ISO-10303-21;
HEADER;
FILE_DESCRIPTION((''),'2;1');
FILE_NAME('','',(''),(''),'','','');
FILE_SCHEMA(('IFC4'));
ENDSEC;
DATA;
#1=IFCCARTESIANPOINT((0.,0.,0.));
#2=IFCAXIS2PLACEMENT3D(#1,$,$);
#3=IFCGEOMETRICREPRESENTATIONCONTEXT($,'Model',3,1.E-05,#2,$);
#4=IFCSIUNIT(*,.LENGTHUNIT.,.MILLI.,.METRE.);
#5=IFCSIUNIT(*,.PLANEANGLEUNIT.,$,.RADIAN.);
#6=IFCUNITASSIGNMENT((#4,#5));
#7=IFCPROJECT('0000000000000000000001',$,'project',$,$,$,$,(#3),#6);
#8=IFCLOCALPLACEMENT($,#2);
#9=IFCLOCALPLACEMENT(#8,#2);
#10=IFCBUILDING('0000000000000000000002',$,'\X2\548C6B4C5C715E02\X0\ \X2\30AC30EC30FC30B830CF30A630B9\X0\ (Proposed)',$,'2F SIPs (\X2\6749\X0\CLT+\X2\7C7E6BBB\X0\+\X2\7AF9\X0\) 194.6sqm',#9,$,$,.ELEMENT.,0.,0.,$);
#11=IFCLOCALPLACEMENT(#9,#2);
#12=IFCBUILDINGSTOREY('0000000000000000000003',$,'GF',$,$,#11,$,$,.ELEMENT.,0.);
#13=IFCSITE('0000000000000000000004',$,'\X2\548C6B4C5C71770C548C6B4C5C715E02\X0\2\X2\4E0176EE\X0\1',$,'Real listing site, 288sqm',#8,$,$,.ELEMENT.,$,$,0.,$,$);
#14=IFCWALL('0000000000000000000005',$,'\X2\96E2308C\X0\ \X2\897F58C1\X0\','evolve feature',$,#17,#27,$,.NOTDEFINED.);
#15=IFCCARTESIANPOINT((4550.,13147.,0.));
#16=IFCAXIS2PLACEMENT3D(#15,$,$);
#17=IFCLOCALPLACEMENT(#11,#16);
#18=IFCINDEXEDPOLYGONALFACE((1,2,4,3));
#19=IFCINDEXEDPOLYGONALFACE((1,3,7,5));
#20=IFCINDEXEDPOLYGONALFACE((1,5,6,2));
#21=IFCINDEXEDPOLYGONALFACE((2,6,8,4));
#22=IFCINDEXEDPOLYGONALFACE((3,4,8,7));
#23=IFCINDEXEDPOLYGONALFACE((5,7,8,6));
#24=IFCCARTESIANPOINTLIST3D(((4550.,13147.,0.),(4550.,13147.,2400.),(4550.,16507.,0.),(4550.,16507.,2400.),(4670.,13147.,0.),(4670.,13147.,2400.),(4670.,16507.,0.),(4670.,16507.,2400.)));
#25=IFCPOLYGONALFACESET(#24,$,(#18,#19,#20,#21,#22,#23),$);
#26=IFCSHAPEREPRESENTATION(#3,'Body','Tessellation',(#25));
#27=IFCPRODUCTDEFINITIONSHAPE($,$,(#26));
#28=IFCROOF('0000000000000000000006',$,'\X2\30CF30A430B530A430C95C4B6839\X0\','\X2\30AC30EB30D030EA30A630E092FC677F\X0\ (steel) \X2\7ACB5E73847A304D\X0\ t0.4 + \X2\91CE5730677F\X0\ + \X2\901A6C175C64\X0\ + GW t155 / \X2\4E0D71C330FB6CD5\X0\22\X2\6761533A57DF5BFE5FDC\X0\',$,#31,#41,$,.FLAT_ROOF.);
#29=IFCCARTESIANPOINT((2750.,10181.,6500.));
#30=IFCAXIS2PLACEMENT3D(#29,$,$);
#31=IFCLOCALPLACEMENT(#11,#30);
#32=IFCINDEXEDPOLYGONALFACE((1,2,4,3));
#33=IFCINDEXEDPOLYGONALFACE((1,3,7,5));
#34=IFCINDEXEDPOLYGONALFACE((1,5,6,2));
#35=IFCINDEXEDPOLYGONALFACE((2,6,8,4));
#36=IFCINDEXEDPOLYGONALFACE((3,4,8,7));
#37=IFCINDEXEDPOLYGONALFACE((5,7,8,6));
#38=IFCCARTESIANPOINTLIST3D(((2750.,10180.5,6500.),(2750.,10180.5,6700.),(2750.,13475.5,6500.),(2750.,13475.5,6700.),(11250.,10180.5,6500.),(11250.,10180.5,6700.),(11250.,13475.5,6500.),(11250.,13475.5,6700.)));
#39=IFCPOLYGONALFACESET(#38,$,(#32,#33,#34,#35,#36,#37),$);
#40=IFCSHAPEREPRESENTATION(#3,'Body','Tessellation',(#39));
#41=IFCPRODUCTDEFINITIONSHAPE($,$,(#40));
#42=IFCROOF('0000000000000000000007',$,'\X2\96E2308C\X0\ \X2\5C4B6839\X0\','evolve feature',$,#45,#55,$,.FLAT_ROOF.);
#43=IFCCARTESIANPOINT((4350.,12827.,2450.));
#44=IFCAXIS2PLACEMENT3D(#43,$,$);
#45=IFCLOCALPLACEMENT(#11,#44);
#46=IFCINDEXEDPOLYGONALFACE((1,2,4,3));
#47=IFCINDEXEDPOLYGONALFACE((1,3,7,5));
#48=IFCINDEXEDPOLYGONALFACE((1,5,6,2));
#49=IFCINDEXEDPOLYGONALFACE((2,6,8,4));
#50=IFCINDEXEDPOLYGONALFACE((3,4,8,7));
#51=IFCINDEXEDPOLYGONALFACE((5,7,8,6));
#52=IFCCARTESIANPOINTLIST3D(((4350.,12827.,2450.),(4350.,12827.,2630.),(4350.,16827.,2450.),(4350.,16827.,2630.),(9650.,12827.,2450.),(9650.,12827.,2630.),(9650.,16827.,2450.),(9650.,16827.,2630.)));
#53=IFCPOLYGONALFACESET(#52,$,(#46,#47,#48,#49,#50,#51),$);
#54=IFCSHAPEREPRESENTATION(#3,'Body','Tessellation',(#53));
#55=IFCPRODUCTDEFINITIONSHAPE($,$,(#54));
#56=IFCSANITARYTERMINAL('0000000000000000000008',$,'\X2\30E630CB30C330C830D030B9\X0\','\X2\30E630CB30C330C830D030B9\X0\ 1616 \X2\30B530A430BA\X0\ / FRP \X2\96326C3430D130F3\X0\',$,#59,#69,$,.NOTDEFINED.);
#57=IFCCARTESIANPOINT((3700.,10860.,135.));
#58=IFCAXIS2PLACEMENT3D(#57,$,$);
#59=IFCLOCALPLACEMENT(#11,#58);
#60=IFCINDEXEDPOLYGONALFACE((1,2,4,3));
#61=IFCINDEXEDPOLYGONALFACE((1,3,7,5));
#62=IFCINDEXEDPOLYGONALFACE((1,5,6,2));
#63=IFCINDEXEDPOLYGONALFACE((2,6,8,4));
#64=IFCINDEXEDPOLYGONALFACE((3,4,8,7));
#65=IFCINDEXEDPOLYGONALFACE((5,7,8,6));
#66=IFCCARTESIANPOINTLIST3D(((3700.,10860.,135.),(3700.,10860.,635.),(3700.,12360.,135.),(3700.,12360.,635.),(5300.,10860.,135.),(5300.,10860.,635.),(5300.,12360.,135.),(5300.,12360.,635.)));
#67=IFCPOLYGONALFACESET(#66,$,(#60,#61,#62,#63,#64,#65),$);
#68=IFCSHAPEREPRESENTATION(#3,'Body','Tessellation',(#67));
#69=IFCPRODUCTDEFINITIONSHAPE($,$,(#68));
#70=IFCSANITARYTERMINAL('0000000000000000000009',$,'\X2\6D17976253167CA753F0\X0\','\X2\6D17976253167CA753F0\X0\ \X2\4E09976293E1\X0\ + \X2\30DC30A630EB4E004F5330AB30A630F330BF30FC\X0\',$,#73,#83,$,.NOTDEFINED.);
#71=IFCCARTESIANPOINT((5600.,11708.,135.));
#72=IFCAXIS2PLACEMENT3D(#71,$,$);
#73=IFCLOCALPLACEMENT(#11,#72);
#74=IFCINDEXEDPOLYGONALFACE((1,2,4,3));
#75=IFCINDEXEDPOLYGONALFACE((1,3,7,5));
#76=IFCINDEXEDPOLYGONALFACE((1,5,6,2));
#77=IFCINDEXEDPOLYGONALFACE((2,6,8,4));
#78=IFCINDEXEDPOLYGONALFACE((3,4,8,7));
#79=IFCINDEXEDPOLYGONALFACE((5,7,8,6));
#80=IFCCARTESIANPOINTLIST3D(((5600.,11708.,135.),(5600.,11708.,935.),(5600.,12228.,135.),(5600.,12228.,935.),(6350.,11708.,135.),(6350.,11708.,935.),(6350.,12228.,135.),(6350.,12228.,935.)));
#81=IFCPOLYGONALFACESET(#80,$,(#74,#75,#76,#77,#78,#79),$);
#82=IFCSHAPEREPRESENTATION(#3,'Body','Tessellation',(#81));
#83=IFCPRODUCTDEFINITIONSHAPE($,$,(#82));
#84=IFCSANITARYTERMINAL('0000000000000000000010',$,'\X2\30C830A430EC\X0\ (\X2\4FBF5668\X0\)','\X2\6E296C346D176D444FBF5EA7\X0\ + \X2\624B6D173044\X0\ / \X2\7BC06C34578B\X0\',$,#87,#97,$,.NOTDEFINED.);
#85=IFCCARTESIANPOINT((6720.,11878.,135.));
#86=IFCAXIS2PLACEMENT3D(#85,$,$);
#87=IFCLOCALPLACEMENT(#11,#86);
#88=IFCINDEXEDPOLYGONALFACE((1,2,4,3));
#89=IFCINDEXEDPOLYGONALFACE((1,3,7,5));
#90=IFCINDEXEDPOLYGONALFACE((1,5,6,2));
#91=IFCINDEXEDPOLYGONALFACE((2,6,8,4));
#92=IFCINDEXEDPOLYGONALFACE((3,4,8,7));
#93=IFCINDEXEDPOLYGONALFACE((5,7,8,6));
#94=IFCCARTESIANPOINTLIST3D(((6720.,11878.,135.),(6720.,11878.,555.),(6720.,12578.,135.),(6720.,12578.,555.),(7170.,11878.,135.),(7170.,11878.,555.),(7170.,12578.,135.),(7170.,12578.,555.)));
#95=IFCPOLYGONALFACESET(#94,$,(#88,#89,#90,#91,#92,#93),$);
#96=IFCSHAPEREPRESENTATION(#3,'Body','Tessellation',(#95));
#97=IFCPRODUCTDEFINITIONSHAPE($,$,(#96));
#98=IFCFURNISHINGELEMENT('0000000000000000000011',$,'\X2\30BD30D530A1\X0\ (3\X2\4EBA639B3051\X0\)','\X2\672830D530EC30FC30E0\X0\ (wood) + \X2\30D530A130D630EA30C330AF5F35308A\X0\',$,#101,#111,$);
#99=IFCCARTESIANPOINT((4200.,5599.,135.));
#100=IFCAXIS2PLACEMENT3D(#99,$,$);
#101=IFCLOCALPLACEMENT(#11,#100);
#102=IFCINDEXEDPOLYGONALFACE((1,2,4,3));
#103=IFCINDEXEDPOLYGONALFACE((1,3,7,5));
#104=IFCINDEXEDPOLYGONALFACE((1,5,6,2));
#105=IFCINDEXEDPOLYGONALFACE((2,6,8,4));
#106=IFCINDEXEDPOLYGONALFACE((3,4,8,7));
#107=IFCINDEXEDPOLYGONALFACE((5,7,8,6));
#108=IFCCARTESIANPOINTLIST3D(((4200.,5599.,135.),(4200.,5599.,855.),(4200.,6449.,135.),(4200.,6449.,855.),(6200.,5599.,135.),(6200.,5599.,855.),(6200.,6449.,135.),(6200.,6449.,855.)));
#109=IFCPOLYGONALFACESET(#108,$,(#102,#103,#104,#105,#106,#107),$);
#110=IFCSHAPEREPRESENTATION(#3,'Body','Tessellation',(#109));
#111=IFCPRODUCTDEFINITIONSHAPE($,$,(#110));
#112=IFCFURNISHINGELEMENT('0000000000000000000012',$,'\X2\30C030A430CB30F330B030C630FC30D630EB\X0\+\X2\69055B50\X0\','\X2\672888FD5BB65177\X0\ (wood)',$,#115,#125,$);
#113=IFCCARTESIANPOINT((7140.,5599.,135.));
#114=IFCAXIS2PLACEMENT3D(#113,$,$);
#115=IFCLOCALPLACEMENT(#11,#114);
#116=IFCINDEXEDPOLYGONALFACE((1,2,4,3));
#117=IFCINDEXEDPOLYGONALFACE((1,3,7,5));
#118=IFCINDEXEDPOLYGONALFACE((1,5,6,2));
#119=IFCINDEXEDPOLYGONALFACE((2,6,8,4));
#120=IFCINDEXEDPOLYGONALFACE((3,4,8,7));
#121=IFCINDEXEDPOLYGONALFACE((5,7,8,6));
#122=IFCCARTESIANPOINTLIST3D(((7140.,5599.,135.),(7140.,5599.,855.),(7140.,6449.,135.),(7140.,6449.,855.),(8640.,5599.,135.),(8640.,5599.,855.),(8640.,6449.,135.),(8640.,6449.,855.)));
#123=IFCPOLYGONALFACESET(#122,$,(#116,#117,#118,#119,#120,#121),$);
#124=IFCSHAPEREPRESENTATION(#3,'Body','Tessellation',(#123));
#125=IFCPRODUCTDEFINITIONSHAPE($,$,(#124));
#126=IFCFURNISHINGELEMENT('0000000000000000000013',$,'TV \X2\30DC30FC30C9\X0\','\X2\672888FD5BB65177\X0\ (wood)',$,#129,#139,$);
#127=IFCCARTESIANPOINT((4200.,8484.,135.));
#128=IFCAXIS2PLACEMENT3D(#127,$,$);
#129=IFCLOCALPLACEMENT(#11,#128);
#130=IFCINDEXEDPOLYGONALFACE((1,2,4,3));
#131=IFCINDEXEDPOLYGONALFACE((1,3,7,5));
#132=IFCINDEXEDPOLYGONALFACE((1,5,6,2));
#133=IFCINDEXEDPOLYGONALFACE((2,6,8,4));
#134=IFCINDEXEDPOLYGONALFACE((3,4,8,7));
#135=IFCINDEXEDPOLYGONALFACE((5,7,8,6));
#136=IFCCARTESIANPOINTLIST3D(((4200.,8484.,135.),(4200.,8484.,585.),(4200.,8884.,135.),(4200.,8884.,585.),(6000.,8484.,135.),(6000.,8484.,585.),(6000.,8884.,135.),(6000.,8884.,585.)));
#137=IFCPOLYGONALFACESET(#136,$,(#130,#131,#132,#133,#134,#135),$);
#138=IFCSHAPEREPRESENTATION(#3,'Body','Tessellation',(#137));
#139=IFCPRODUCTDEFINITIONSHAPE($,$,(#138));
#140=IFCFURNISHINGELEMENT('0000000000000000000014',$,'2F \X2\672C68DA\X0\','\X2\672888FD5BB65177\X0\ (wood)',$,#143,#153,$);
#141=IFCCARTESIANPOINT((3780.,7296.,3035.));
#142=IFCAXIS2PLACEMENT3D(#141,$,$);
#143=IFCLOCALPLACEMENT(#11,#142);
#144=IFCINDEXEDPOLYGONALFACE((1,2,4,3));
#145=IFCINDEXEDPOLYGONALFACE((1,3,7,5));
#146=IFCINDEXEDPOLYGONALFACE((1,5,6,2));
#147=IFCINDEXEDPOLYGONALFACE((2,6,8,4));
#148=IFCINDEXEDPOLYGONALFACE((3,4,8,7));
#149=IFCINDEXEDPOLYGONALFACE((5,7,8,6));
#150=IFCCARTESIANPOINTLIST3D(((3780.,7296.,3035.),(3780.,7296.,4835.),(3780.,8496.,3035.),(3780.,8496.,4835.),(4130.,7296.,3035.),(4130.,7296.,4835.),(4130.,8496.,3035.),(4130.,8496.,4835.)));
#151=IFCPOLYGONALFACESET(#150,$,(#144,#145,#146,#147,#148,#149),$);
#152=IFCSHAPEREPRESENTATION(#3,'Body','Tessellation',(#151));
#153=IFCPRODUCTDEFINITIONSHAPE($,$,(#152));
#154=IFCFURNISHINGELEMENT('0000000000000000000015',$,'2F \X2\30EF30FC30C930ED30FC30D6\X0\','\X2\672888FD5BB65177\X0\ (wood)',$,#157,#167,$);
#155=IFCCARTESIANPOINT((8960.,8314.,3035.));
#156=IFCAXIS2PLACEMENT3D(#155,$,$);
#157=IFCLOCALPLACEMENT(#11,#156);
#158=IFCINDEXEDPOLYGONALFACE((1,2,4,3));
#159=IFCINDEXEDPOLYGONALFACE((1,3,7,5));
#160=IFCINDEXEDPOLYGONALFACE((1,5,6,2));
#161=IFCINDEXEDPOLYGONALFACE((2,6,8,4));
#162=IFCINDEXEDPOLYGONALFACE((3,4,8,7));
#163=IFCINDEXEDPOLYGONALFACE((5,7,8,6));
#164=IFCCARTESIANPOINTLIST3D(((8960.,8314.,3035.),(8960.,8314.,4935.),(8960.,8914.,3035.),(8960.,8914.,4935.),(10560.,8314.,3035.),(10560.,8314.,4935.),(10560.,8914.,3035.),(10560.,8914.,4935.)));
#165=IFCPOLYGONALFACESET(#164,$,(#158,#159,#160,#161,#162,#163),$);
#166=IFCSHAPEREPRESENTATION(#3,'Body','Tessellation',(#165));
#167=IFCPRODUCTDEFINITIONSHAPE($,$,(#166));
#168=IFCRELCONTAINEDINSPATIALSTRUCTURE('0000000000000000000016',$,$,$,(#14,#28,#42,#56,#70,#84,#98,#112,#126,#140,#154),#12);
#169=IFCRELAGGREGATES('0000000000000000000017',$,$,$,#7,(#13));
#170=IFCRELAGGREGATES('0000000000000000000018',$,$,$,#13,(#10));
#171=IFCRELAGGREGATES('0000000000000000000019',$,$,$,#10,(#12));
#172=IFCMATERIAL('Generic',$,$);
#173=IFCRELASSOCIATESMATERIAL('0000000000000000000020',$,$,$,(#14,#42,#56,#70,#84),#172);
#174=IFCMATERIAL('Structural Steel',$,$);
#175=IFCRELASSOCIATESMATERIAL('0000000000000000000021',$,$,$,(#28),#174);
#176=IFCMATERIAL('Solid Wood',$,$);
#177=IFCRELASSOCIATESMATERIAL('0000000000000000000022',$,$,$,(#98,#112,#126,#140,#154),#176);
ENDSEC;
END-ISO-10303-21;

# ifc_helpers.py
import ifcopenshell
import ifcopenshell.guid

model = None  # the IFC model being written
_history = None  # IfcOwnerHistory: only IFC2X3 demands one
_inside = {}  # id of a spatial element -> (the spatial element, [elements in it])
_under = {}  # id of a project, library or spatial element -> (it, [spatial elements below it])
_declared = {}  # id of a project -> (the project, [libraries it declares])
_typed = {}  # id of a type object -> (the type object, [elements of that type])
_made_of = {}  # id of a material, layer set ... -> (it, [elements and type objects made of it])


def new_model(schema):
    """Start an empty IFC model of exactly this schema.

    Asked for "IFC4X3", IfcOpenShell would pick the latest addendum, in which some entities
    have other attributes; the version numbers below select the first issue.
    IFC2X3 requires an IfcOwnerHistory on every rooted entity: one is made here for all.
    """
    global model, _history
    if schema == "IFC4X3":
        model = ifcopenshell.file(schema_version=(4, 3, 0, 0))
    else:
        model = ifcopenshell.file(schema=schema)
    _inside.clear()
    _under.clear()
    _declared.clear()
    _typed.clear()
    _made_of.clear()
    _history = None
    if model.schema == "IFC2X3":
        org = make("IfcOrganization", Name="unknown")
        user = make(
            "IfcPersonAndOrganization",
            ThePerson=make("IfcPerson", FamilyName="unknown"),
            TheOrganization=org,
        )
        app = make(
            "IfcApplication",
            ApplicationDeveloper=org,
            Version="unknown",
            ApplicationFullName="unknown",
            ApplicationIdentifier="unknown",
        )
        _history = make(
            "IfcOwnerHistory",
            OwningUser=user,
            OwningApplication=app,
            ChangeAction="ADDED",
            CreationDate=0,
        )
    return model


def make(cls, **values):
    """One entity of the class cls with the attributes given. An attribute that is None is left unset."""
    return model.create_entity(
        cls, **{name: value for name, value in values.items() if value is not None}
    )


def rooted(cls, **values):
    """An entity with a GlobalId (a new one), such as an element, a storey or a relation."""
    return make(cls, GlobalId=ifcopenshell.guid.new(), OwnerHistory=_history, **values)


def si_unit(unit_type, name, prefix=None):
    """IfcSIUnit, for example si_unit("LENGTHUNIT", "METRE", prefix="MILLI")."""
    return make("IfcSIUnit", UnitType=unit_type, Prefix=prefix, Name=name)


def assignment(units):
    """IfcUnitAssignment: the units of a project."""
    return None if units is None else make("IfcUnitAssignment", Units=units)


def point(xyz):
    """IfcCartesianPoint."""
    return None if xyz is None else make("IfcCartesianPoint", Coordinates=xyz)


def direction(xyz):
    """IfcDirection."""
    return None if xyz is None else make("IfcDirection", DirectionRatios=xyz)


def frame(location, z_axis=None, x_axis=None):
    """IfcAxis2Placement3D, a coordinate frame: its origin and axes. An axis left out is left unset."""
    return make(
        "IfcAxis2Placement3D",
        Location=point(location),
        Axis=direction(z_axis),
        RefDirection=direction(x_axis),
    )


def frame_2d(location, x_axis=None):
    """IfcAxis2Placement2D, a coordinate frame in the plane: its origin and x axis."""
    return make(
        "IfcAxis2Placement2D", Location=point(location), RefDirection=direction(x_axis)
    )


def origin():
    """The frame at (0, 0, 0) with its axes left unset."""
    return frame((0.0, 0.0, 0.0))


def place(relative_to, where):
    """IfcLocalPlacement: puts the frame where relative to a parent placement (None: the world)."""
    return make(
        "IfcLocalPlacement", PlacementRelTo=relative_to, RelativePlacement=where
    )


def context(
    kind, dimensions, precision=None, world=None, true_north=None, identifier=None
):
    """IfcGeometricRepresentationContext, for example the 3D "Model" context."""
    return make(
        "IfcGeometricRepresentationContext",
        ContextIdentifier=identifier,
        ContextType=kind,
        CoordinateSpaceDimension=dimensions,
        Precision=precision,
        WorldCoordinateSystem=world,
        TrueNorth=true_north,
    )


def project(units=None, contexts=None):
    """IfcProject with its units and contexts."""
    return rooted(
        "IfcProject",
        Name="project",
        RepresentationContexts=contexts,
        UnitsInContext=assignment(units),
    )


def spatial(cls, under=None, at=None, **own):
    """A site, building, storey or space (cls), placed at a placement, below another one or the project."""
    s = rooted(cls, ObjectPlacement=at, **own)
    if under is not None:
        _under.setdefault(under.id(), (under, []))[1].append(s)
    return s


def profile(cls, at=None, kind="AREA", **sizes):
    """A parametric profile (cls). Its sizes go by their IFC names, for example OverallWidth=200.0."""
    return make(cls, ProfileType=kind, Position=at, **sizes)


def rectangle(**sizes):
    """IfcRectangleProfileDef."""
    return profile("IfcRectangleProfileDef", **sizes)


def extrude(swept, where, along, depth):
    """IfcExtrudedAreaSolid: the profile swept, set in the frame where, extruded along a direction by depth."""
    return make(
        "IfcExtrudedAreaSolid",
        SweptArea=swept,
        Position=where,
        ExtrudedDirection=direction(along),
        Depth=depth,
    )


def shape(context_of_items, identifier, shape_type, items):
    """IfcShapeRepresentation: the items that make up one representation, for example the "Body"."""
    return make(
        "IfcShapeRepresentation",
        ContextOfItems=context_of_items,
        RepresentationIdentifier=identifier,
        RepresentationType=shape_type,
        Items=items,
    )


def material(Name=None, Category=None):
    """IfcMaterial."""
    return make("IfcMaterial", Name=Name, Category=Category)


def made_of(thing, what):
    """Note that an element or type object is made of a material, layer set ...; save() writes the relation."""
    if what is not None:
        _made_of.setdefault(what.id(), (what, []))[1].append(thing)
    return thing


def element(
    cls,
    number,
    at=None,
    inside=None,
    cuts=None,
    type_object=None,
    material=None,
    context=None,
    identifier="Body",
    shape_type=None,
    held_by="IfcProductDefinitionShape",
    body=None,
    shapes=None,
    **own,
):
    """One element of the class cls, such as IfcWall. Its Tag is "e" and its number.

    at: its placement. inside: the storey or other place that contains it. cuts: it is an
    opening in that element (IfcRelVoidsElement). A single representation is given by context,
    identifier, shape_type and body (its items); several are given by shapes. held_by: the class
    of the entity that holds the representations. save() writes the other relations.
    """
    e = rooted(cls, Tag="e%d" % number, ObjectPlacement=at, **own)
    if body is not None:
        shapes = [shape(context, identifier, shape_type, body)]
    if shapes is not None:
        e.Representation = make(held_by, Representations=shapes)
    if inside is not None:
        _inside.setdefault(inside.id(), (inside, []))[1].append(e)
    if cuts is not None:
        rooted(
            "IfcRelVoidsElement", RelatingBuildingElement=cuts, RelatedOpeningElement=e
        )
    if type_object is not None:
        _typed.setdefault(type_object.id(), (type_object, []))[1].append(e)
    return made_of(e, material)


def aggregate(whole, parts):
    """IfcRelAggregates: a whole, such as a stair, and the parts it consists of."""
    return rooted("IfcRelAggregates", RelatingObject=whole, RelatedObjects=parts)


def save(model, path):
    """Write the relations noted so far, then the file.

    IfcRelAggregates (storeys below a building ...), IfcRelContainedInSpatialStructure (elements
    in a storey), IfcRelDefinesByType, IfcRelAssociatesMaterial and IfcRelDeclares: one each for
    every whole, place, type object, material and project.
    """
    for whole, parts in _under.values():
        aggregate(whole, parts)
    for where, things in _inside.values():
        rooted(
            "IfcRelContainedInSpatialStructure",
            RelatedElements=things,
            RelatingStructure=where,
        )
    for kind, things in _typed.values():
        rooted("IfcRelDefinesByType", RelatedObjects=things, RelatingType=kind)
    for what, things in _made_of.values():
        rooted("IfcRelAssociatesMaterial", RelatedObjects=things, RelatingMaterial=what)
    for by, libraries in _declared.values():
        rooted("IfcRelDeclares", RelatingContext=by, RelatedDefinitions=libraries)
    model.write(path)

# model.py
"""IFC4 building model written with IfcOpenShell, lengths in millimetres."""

from ifc_helpers import new_model, si_unit, frame, frame_2d, origin, place, context, project, spatial, rectangle, extrude, material, element, save


model = new_model("IFC4")

# Units and contexts
model_context = context("Model", 3, precision=1e-05, world=origin())
ifc_project = project(units=[si_unit("LENGTHUNIT", "METRE", prefix="MILLI"), si_unit("PLANEANGLEUNIT", "RADIAN")], contexts=[model_context])

# Site, building, storey
site_placement = place(None, origin())
site = spatial("IfcSite", under=ifc_project, at=site_placement, Name="和歌山県和歌山市2丁目1", ObjectType="Real listing site, 288sqm", CompositionType="ELEMENT", RefElevation=0.0)
building_placement = place(site_placement, origin())
building = spatial("IfcBuilding", under=site, at=building_placement, Name="和歌山市 ガレージハウス (Proposed)", ObjectType="2F SIPs (杉CLT+籾殻+竹) 194.6sqm", CompositionType="ELEMENT", ElevationOfRefHeight=0.0, ElevationOfTerrain=0.0)
storey_placement = place(building_placement, origin())
storey = spatial("IfcBuildingStorey", under=building, at=storey_placement, Name="GF", CompositionType="ELEMENT", Elevation=0.0)

# Shared definitions
ifc_material_1 = material(Name="Generic")

# Shared definitions
ifc_material_2 = material(Name="Solid Wood")

# Wall
wall_1_placement = place(storey_placement, frame((4550.0, 13147.0, 0.0)))
element("IfcWall", 1, at=wall_1_placement, inside=storey, material=ifc_material_1, Name="離れ 西壁", Description="evolve feature", PredefinedType="NOTDEFINED", context=model_context, shape_type="SweptSolid", body=[
    extrude(rectangle(XDim=120.0, YDim=3360.0, at=frame_2d((60.0, 1680.0))), frame((4550.0, 13147.0, 0.0)), (0.0, 0.0, 1.0), 2400.0),
])

# Roofs
ifc_material_3 = material(Name="Structural Steel")
roof_1_placement = place(storey_placement, frame((2750.0, 10181.0, 6500.0)))
element("IfcRoof", 2, at=roof_1_placement, inside=storey, material=ifc_material_3, Name="ハイサイド屋根", Description="ガルバリウム鋼板 (steel) 立平葺き t0.4 + 野地板 + 通気層 + GW t155 / 不燃・法22条区域対応", PredefinedType="FLAT_ROOF", context=model_context, shape_type="SweptSolid", body=[
    extrude(rectangle(XDim=8500.0, YDim=3295.0, at=frame_2d((4250.0, 1647.0))), frame((2750.0, 10181.0, 6500.0)), (0.0, 0.0, 1.0), 200.0),
])
roof_2_placement = place(storey_placement, frame((4350.0, 12827.0, 2450.0)))
element("IfcRoof", 3, at=roof_2_placement, inside=storey, material=ifc_material_1, Name="離れ 屋根", Description="evolve feature", PredefinedType="FLAT_ROOF", context=model_context, shape_type="SweptSolid", body=[
    extrude(rectangle(XDim=5300.0, YDim=4000.0, at=frame_2d((2650.0, 2000.0))), frame((4350.0, 12827.0, 2450.0)), (0.0, 0.0, 1.0), 180.0),
])

# Sanitary terminals
sanitary_terminal_1_placement = place(storey_placement, frame((3700.0, 10860.0, 135.0)))
element("IfcSanitaryTerminal", 4, at=sanitary_terminal_1_placement, inside=storey, material=ifc_material_1, Name="ユニットバス", Description="ユニットバス 1616 サイズ / FRP 防水パン", PredefinedType="NOTDEFINED", context=model_context, shape_type="SweptSolid", body=[
    extrude(rectangle(XDim=1600.0, YDim=1500.0, at=frame_2d((800.0, 750.0))), frame((3700.0, 10860.0, 135.0)), (0.0, 0.0, 1.0), 500.0),
])
sanitary_terminal_2_placement = place(storey_placement, frame((5600.0, 11708.0, 135.0)))
element("IfcSanitaryTerminal", 5, at=sanitary_terminal_2_placement, inside=storey, material=ifc_material_1, Name="洗面化粧台", Description="洗面化粧台 三面鏡 + ボウル一体カウンター", PredefinedType="NOTDEFINED", context=model_context, shape_type="SweptSolid", body=[
    extrude(rectangle(XDim=750.0, YDim=520.0, at=frame_2d((375.0, 260.0))), frame((5600.0, 11708.0, 135.0)), (0.0, 0.0, 1.0), 800.0),
])
sanitary_terminal_3_placement = place(storey_placement, frame((6720.0, 11878.0, 135.0)))
element("IfcSanitaryTerminal", 6, at=sanitary_terminal_3_placement, inside=storey, material=ifc_material_1, Name="トイレ (便器)", Description="温水洗浄便座 + 手洗い / 節水型", PredefinedType="NOTDEFINED", context=model_context, shape_type="SweptSolid", body=[
    extrude(rectangle(XDim=450.0, YDim=700.0, at=frame_2d((225.0, 350.0))), frame((6720.0, 11878.0, 135.0)), (0.0, 0.0, 1.0), 420.0),
])

# Furnishing elements
furnishing_1_placement = place(storey_placement, frame((4200.0, 5599.0, 135.0)))
element("IfcFurnishingElement", 7, at=furnishing_1_placement, inside=storey, material=ifc_material_2, Name="ソファ (3人掛け)", Description="木フレーム (wood) + ファブリック張り", context=model_context, shape_type="SweptSolid", body=[
    extrude(rectangle(XDim=2000.0, YDim=850.0, at=frame_2d((1000.0, 425.0))), frame((4200.0, 5599.0, 135.0)), (0.0, 0.0, 1.0), 720.0),
])
furnishing_2_placement = place(storey_placement, frame((7140.0, 5599.0, 135.0)))
element("IfcFurnishingElement", 8, at=furnishing_2_placement, inside=storey, material=ifc_material_2, Name="ダイニングテーブル+椅子", Description="木製家具 (wood)", context=model_context, shape_type="SweptSolid", body=[
    extrude(rectangle(XDim=1500.0, YDim=850.0, at=frame_2d((750.0, 425.0))), frame((7140.0, 5599.0, 135.0)), (0.0, 0.0, 1.0), 720.0),
])
furnishing_3_placement = place(storey_placement, frame((4200.0, 8484.0, 135.0)))
element("IfcFurnishingElement", 9, at=furnishing_3_placement, inside=storey, material=ifc_material_2, Name="TV ボード", Description="木製家具 (wood)", context=model_context, shape_type="SweptSolid", body=[
    extrude(rectangle(XDim=1800.0, YDim=400.0, at=frame_2d((900.0, 200.0))), frame((4200.0, 8484.0, 135.0)), (0.0, 0.0, 1.0), 450.0),
])
furnishing_4_placement = place(storey_placement, frame((3780.0, 7296.0, 3035.0)))
element("IfcFurnishingElement", 10, at=furnishing_4_placement, inside=storey, material=ifc_material_2, Name="2F 本棚", Description="木製家具 (wood)", context=model_context, shape_type="SweptSolid", body=[
    extrude(rectangle(XDim=350.0, YDim=1200.0, at=frame_2d((175.0, 600.0))), frame((3780.0, 7296.0, 3035.0)), (0.0, 0.0, 1.0), 1800.0),
])
furnishing_5_placement = place(storey_placement, frame((8960.0, 8314.0, 3035.0)))
element("IfcFurnishingElement", 11, at=furnishing_5_placement, inside=storey, material=ifc_material_2, Name="2F ワードローブ", Description="木製家具 (wood)", context=model_context, shape_type="SweptSolid", body=[
    extrude(rectangle(XDim=1600.0, YDim=600.0, at=frame_2d((800.0, 300.0))), frame((8960.0, 8314.0, 3035.0)), (0.0, 0.0, 1.0), 1900.0),
])

save(model, "model.ifc")
